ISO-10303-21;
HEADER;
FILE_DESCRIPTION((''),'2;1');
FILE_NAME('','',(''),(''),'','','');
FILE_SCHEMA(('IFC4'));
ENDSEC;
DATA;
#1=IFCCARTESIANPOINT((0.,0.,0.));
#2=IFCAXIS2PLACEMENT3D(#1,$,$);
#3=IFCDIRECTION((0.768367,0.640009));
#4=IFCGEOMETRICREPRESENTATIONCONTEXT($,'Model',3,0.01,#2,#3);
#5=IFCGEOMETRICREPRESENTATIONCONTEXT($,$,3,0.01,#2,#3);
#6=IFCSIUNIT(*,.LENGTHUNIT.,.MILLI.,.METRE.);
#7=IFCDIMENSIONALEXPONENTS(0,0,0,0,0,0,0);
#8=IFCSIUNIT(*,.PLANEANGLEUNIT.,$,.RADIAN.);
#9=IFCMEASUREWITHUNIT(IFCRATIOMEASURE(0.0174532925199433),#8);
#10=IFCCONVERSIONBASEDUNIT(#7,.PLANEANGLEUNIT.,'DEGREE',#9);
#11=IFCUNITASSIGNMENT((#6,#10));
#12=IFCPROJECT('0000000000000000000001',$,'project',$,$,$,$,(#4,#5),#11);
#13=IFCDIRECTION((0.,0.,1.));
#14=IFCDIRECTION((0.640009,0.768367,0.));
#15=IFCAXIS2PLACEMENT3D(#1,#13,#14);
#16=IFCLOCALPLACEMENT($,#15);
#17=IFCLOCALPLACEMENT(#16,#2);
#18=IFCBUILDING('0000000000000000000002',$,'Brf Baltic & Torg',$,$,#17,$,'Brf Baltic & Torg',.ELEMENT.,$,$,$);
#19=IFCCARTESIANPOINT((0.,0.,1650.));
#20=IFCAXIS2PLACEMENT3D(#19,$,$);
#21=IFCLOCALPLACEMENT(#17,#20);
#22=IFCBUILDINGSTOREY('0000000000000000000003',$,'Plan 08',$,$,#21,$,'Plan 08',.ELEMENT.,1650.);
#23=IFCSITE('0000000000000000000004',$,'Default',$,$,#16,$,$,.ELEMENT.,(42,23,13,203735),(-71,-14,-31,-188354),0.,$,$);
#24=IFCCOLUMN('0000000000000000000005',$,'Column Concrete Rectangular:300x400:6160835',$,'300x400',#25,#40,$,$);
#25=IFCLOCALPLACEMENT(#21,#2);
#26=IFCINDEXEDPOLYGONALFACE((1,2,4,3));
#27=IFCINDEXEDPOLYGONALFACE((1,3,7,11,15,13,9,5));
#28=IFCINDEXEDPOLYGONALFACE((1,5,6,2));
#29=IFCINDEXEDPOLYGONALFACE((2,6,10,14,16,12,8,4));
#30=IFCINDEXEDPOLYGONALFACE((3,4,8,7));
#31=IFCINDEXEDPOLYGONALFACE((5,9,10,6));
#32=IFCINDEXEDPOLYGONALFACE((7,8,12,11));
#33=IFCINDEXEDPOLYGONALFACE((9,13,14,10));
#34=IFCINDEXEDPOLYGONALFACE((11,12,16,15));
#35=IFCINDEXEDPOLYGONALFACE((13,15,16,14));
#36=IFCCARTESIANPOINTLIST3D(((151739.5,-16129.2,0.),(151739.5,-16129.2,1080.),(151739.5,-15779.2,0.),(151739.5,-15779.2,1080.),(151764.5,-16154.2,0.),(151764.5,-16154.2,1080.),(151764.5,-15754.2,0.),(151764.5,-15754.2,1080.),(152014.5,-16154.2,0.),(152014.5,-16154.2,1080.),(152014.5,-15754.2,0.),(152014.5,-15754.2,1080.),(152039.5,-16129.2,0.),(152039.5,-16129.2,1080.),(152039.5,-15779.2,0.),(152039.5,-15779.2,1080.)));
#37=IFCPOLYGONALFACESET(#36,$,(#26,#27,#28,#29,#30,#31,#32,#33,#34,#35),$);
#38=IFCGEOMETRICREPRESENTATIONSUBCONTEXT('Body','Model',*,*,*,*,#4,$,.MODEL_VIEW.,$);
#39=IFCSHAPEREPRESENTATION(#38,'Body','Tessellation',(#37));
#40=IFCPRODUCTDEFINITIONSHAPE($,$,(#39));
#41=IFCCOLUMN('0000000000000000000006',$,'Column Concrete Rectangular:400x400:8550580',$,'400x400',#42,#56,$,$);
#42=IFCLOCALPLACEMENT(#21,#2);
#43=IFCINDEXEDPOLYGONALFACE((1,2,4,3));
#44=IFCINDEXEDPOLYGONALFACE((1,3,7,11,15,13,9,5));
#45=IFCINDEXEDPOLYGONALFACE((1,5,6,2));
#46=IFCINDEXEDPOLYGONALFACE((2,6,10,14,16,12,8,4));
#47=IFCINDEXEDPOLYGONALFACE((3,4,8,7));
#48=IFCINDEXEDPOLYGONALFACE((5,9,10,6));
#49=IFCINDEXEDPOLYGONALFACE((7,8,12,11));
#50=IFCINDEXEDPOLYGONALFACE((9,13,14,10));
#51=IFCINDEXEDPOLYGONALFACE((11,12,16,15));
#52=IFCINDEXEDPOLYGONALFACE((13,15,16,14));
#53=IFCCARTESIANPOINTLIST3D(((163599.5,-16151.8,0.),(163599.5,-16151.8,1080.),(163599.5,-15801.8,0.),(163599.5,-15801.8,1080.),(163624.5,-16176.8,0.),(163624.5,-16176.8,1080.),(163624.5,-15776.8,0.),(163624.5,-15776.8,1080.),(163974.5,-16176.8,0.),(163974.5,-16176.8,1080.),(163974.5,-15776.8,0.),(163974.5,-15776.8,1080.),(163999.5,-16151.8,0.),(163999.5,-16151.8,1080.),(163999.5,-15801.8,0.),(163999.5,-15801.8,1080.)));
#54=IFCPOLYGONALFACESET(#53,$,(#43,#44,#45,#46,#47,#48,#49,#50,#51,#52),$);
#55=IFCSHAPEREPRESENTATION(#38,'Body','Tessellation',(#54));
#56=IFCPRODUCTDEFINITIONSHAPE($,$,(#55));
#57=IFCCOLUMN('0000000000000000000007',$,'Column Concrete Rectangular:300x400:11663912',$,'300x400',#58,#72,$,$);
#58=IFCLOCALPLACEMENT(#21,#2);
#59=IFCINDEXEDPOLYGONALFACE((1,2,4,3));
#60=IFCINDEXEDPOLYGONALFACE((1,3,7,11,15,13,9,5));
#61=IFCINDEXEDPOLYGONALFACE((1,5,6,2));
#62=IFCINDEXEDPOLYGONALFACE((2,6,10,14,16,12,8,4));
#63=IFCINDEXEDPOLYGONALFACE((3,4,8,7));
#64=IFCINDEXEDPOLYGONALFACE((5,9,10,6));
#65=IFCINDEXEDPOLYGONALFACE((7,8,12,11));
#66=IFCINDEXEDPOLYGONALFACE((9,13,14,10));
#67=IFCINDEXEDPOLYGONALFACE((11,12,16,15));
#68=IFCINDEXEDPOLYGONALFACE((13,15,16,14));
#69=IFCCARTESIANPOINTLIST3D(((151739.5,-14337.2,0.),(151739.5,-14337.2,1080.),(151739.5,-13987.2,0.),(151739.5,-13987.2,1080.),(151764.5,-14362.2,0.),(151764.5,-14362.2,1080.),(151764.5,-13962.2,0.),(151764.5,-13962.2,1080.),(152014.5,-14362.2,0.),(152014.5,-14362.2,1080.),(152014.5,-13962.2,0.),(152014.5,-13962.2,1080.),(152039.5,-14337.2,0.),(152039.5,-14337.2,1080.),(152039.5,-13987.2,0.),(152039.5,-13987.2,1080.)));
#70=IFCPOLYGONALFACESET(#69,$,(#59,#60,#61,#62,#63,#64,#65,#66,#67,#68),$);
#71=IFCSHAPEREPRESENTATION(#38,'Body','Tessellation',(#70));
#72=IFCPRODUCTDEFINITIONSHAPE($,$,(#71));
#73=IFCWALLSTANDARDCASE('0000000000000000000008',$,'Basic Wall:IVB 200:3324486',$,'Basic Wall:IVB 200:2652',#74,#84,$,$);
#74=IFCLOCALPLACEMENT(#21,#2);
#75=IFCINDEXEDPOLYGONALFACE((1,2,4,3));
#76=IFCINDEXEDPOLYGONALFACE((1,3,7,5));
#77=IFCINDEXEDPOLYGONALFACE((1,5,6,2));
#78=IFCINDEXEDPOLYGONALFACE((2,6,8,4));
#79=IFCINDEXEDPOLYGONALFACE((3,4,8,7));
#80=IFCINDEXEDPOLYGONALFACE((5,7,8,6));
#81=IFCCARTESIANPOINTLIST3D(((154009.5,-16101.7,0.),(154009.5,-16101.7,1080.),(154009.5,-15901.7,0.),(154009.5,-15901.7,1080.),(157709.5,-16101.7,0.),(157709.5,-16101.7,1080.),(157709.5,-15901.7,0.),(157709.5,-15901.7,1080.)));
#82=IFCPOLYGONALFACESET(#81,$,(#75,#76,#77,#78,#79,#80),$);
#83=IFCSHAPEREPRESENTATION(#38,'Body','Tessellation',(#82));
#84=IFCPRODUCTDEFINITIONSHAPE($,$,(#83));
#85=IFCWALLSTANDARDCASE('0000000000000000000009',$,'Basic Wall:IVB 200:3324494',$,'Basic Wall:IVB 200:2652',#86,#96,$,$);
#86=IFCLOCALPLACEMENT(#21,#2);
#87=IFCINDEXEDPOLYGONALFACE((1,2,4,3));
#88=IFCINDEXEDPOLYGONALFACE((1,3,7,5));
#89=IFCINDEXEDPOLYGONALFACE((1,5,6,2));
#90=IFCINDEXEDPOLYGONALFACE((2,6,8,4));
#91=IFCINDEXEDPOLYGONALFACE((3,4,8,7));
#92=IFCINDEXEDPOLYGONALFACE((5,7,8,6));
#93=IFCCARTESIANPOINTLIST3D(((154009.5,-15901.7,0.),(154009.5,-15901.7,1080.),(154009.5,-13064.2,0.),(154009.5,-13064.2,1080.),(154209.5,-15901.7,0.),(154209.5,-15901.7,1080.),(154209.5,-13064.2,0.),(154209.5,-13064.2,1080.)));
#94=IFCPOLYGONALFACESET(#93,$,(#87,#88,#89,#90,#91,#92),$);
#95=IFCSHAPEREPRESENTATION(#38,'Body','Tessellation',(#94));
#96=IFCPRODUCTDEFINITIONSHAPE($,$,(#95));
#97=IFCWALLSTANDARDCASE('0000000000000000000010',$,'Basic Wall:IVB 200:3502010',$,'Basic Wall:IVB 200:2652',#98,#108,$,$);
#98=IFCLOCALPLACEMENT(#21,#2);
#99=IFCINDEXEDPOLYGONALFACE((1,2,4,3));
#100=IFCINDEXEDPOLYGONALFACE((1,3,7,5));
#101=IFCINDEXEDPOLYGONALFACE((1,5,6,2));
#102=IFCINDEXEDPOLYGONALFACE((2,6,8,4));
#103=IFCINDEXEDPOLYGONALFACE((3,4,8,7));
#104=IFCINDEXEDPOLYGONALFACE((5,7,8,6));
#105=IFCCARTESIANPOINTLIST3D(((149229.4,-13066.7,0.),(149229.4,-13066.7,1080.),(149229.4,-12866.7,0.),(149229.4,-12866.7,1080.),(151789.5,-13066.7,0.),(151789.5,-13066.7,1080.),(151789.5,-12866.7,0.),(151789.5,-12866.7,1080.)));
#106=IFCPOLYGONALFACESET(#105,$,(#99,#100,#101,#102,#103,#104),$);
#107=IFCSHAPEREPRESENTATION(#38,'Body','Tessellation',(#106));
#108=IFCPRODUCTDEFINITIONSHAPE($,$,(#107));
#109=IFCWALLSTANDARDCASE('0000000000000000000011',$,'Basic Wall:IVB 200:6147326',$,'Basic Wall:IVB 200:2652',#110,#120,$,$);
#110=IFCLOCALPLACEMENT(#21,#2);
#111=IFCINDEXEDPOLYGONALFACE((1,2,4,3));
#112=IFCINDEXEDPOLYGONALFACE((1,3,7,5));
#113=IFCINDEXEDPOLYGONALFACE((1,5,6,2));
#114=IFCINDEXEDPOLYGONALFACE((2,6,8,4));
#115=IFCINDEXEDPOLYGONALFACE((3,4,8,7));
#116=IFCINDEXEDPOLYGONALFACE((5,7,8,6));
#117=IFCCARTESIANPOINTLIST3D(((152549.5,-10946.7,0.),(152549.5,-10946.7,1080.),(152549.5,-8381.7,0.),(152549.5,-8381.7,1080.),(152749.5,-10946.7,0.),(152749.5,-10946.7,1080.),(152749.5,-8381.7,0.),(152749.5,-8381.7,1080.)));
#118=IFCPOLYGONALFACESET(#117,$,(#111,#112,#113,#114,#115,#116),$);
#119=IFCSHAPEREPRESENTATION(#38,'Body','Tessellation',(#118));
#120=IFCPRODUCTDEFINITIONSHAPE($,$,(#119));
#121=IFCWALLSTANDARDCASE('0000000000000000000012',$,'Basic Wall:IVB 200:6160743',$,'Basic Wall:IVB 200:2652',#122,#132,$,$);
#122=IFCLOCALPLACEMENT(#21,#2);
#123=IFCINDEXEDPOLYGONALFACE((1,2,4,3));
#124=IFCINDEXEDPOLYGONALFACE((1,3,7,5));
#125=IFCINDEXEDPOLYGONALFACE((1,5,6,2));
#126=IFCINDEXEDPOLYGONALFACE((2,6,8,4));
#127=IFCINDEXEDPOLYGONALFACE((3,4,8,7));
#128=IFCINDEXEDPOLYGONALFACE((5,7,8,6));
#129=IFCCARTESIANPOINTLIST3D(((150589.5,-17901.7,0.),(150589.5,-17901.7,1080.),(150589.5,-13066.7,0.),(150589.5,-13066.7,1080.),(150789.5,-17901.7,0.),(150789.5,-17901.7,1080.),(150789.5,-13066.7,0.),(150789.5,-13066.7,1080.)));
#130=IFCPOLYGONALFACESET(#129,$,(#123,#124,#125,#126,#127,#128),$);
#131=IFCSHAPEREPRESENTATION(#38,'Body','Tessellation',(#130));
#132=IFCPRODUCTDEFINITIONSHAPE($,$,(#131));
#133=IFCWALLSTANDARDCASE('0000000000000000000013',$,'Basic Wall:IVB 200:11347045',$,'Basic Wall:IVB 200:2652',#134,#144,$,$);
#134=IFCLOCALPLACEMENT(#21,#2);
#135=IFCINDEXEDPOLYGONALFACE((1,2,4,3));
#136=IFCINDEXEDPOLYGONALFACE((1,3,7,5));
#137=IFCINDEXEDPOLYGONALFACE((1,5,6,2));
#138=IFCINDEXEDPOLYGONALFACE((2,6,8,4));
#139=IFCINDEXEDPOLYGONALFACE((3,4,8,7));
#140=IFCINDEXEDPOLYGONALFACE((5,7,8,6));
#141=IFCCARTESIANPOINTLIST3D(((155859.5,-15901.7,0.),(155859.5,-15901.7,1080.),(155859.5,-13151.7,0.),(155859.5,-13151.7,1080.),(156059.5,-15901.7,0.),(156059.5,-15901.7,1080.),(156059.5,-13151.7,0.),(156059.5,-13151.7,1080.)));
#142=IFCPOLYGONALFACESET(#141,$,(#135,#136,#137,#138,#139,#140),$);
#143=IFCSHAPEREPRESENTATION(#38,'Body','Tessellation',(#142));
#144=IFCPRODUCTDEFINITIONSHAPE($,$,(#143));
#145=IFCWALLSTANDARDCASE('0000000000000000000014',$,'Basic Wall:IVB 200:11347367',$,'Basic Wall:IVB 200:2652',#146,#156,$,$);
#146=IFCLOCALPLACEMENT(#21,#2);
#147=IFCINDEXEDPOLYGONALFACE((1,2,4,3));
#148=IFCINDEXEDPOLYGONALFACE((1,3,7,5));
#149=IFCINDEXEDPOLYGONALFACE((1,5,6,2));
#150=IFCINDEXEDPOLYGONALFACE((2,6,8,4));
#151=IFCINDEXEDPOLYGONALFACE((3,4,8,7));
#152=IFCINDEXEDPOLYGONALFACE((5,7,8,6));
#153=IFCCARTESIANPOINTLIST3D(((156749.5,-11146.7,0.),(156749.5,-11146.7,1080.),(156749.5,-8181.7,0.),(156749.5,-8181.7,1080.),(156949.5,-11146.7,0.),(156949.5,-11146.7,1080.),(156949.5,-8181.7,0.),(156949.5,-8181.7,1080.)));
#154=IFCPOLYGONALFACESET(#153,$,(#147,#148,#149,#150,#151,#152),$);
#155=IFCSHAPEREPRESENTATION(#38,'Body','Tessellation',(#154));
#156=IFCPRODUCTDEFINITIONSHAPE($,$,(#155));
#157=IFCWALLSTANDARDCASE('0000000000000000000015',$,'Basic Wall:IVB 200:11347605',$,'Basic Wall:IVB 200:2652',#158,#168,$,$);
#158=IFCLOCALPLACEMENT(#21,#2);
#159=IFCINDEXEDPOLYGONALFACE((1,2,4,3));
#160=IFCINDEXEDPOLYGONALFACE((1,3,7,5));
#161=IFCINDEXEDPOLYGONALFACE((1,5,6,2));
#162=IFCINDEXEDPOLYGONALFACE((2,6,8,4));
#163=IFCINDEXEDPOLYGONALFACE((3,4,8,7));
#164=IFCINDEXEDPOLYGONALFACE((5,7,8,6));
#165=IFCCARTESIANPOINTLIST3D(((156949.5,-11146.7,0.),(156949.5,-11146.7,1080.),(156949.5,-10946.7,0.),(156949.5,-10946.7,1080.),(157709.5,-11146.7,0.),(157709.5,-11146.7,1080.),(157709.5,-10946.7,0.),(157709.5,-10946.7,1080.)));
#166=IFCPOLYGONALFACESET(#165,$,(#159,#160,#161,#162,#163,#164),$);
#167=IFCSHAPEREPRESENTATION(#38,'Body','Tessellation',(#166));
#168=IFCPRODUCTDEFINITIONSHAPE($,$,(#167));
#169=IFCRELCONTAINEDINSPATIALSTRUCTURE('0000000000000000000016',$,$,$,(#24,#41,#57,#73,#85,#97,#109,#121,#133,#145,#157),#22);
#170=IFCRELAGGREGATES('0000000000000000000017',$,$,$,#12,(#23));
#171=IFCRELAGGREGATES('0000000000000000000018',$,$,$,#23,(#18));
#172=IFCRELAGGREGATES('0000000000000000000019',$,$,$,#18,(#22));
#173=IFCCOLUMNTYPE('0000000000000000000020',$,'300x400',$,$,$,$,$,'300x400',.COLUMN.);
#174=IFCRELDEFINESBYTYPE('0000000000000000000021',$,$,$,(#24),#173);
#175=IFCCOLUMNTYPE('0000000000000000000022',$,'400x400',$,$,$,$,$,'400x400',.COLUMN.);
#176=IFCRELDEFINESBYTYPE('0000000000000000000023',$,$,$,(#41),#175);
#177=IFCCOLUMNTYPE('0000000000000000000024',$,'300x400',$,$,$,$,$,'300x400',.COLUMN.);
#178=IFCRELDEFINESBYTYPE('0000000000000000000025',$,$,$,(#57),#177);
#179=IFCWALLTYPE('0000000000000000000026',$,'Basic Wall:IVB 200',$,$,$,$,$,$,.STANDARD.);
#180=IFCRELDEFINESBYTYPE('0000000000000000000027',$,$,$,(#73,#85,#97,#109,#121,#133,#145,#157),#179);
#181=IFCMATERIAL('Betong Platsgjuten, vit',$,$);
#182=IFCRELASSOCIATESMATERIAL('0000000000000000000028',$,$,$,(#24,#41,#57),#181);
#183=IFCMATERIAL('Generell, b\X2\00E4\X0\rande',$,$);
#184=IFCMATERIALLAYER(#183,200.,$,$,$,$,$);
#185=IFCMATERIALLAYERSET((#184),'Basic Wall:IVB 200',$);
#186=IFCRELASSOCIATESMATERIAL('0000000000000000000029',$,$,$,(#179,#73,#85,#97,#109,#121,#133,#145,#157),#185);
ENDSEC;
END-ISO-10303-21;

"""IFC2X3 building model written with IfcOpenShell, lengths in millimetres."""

from ifc_helpers import new_model, entity, si_unit, converted_unit, direction, frame, frame_2d, origin, place, context, subcontext, project, spatial, polyline, rectangle, outline, extrude, clip, halfspace, source, transform, mapped, material, layer, layer_set, layer_usage, type_object, type_shapes, element, save


model = new_model("IFC2X3")

# Units and contexts
model_context = context("Model", 3, precision=0.01, world=origin(), true_north=direction((0.768367, 0.640009)))
context_of_model = context(None, 3, precision=0.01, world=origin(), true_north=direction((0.768367, 0.640009)))
body_context = subcontext(model_context, "Body", "Model", "MODEL_VIEW")
ifc_project = project(units=[si_unit("LENGTHUNIT", "METRE", prefix="MILLI"), converted_unit("PLANEANGLEUNIT", "DEGREE", entity("IfcRatioMeasure", 0.0174532925199433), si_unit("PLANEANGLEUNIT", "RADIAN"), dimensions=[0, 0, 0, 0, 0, 0, 0])], contexts=[model_context, context_of_model])

# Site, building, storey
site_placement = place(None, frame((0.0, 0.0, 0.0), z_axis=(0.0, 0.0, 1.0), x_axis=(0.640009, 0.768367, 0.0)))
site = spatial("IfcSite", under=ifc_project, at=site_placement, Name="Default", CompositionType="ELEMENT", RefLatitude=(42, 23, 13, 203735), RefLongitude=(-71, -14, -31, -188354), RefElevation=0.0)
building_placement = place(site_placement, origin())
building = spatial("IfcBuilding", under=site, at=building_placement, Name="Brf Baltic & Torg", LongName="Brf Baltic & Torg", CompositionType="ELEMENT")
storey_placement = place(building_placement, frame((0.0, 0.0, 1650.0)))
storey = spatial("IfcBuildingStorey", under=building, at=storey_placement, Name="Plan 08", LongName="Plan 08", CompositionType="ELEMENT", Elevation=1650.0)

# Columns
ifc_material_1 = material(Name="Betong Platsgjuten, vit")
column_type_1 = type_object("IfcColumnType", Name="300x400", ElementType="300x400", PredefinedType="COLUMN")
shared_shape_1 = source(origin(), body_context, "Body", "SweptSolid", [
    extrude(outline(polyline([(-175.0, -150.0), (175.0, -150.0), (200.0, -125.0), (200.0, 125.0), (175.0, 150.0), (-175.0, 150.0), (-200.0, 125.0), (-200.0, -125.0), (-175.0, -150.0)])), frame((0.0, 0.0, 1650.0), z_axis=(0.0, 0.0, 1.0), x_axis=(0.0, -1.0, 0.0)), (0.0, 0.0, 1.0), 1080.0),
])
type_shapes(column_type_1, [shared_shape_1])
column_1_placement = place(storey_placement, frame((151889.5, -15954.2, -1650.0)))
element("IfcColumn", 1, at=column_1_placement, inside=storey, type_object=column_type_1, material=ifc_material_1, Name="Column Concrete Rectangular:300x400:6160835", ObjectType="300x400", context=body_context, shape_type="MappedRepresentation", body=[
    mapped(shared_shape_1, transform((0.0, 0.0, 0.0), scale=1.0)),
])
column_type_2 = type_object("IfcColumnType", Name="400x400", ElementType="400x400", PredefinedType="COLUMN")
shared_shape_2 = source(origin(), body_context, "Body", "SweptSolid", [
    extrude(outline(polyline([(-175.0, -200.0), (175.0, -200.0), (200.0, -175.0), (200.0, 175.0), (175.0, 200.0), (-175.0, 200.0), (-200.0, 175.0), (-200.0, -175.0), (-175.0, -200.0)])), frame((0.0, 0.0, 1650.0), z_axis=(0.0, 0.0, 1.0), x_axis=(0.0, -1.0, 0.0)), (0.0, 0.0, 1.0), 1080.0),
])
type_shapes(column_type_2, [shared_shape_2])
column_2_placement = place(storey_placement, frame((163799.5, -15976.8, -1650.0)))
element("IfcColumn", 2, at=column_2_placement, inside=storey, type_object=column_type_2, material=ifc_material_1, Name="Column Concrete Rectangular:400x400:8550580", ObjectType="400x400", context=body_context, shape_type="MappedRepresentation", body=[
    mapped(shared_shape_2, transform((0.0, 0.0, 0.0), scale=1.0)),
])
column_type_3 = type_object("IfcColumnType", Name="300x400", ElementType="300x400", PredefinedType="COLUMN")
shared_shape_3 = source(origin(), body_context, "Body", "SweptSolid", [
    extrude(outline(polyline([(-175.0, -150.0), (175.0, -150.0), (200.0, -125.0), (200.0, 125.0), (175.0, 150.0), (-175.0, 150.0), (-200.0, 125.0), (-200.0, -125.0), (-175.0, -150.0)])), frame((0.0, 0.0, 1650.0), z_axis=(0.0, 0.0, 1.0), x_axis=(0.0, -1.0, 0.0)), (0.0, 0.0, 1.0), 1080.0),
])
type_shapes(column_type_3, [shared_shape_3])
column_3_placement = place(storey_placement, frame((151889.5, -14162.2, -1650.0)))
element("IfcColumn", 3, at=column_3_placement, inside=storey, type_object=column_type_3, material=ifc_material_1, Name="Column Concrete Rectangular:300x400:11663912", ObjectType="300x400", context=body_context, shape_type="MappedRepresentation", body=[
    mapped(shared_shape_3, transform((0.0, 0.0, 0.0), scale=1.0)),
])

# Walls
ifc_material_2 = material(Name="Generell, bärande")
ifc_layer = layer(ifc_material_2, 200.0)
ifc_layer_set = layer_set([ifc_layer], Name="Basic Wall:IVB 200")
ifc_layer_usage_1 = layer_usage(ifc_layer_set, "AXIS2", "NEGATIVE", 100.0)
wall_type = type_object("IfcWallType", Name="Basic Wall:IVB 200", PredefinedType="STANDARD", material=ifc_layer_set)
wall_1_placement = place(storey_placement, frame((157709.5, -16001.7, 0.0), z_axis=(0.0, 0.0, 1.0), x_axis=(-1.0, 0.0, 0.0)))
element("IfcWallStandardCase", 4, at=wall_1_placement, inside=storey, type_object=wall_type, material=ifc_layer_usage_1, Name="Basic Wall:IVB 200:3324486", ObjectType="Basic Wall:IVB 200:2652", context=body_context, shape_type="Clipping", body=[
    clip(extrude(rectangle(XDim=3700.0, YDim=200.0, at=frame_2d((1850.0, 0.0), x_axis=(-1.0, 0.0))), origin(), (0.0, 0.0, 1.0), 1080.0), halfspace(origin(), True)),
])
ifc_layer_usage_2 = layer_usage(ifc_layer_set, "AXIS2", "NEGATIVE", 100.0)
wall_2_placement = place(storey_placement, frame((154109.5, -15901.7, 0.0), z_axis=(0.0, 0.0, 1.0), x_axis=(0.0, 1.0, 0.0)))
element("IfcWallStandardCase", 5, at=wall_2_placement, inside=storey, type_object=wall_type, material=ifc_layer_usage_2, Name="Basic Wall:IVB 200:3324494", ObjectType="Basic Wall:IVB 200:2652", context=body_context, shape_type="Clipping", body=[
    clip(extrude(rectangle(XDim=2837.5, YDim=200.0, at=frame_2d((1418.7, 0.0), x_axis=(-1.0, 0.0))), origin(), (0.0, 0.0, 1.0), 1080.0), halfspace(origin(), True)),
])

# Wall
ifc_layer_usage_3 = layer_usage(ifc_layer_set, "AXIS2", "NEGATIVE", 100.0)
wall_3_placement = place(storey_placement, frame((151789.5, -12966.7, 0.0), z_axis=(0.0, 0.0, 1.0), x_axis=(-1.0, 0.0, 0.0)))
element("IfcWallStandardCase", 6, at=wall_3_placement, inside=storey, type_object=wall_type, material=ifc_layer_usage_3, Name="Basic Wall:IVB 200:3502010", ObjectType="Basic Wall:IVB 200:2652", context=body_context, shape_type="Clipping", body=[
    clip(extrude(rectangle(XDim=2560.1, YDim=200.0, at=frame_2d((1280.0, 0.0), x_axis=(-1.0, 0.0))), origin(), (0.0, 0.0, 1.0), 1080.0), halfspace(origin(), True)),
])

# Walls
ifc_layer_usage_4 = layer_usage(ifc_layer_set, "AXIS2", "NEGATIVE", 100.0)
wall_4_placement = place(storey_placement, frame((152649.5, -10946.7, 0.0), z_axis=(0.0, 0.0, 1.0), x_axis=(0.0, 1.0, 0.0)))
element("IfcWallStandardCase", 7, at=wall_4_placement, inside=storey, type_object=wall_type, material=ifc_layer_usage_4, Name="Basic Wall:IVB 200:6147326", ObjectType="Basic Wall:IVB 200:2652", context=body_context, shape_type="Clipping", body=[
    clip(extrude(rectangle(XDim=2565.0, YDim=200.0, at=frame_2d((1282.5, 0.0), x_axis=(-1.0, 0.0))), origin(), (0.0, 0.0, 1.0), 1080.0), halfspace(origin(), True)),
])
ifc_layer_usage_5 = layer_usage(ifc_layer_set, "AXIS2", "POSITIVE", -100.0)
wall_5_placement = place(storey_placement, frame((150689.5, -13066.7, 0.0), z_axis=(0.0, 0.0, 1.0), x_axis=(0.0, -1.0, 0.0)))
element("IfcWallStandardCase", 8, at=wall_5_placement, inside=storey, type_object=wall_type, material=ifc_layer_usage_5, Name="Basic Wall:IVB 200:6160743", ObjectType="Basic Wall:IVB 200:2652", context=body_context, shape_type="Clipping", body=[
    clip(extrude(rectangle(XDim=4835.0, YDim=200.0, at=frame_2d((2417.5, 0.0), x_axis=(-1.0, 0.0))), origin(), (0.0, 0.0, 1.0), 1080.0), halfspace(origin(), True)),
])
ifc_layer_usage_6 = layer_usage(ifc_layer_set, "AXIS2", "NEGATIVE", 100.0)
wall_6_placement = place(storey_placement, frame((155959.5, -15901.7, 0.0), z_axis=(0.0, 0.0, 1.0), x_axis=(0.0, 1.0, 0.0)))
element("IfcWallStandardCase", 9, at=wall_6_placement, inside=storey, type_object=wall_type, material=ifc_layer_usage_6, Name="Basic Wall:IVB 200:11347045", ObjectType="Basic Wall:IVB 200:2652", context=body_context, shape_type="Clipping", body=[
    clip(extrude(rectangle(XDim=2750.0, YDim=200.0, at=frame_2d((1375.0, 0.0), x_axis=(-1.0, 0.0))), origin(), (0.0, 0.0, 1.0), 1080.0), halfspace(origin(), True)),
])
ifc_layer_usage_7 = layer_usage(ifc_layer_set, "AXIS2", "POSITIVE", -100.0)
wall_7_placement = place(storey_placement, frame((156849.5, -8181.7, 0.0), z_axis=(0.0, 0.0, 1.0), x_axis=(0.0, -1.0, 0.0)))
element("IfcWallStandardCase", 10, at=wall_7_placement, inside=storey, type_object=wall_type, material=ifc_layer_usage_7, Name="Basic Wall:IVB 200:11347367", ObjectType="Basic Wall:IVB 200:2652", context=body_context, shape_type="Clipping", body=[
    clip(extrude(rectangle(XDim=2965.0, YDim=200.0, at=frame_2d((1482.5, 0.0), x_axis=(-1.0, 0.0))), origin(), (0.0, 0.0, 1.0), 1080.0), halfspace(origin(), True)),
])
ifc_layer_usage_8 = layer_usage(ifc_layer_set, "AXIS2", "NEGATIVE", 100.0)
wall_8_placement = place(storey_placement, frame((156949.5, -11046.7, 0.0)))
element("IfcWallStandardCase", 11, at=wall_8_placement, inside=storey, type_object=wall_type, material=ifc_layer_usage_8, Name="Basic Wall:IVB 200:11347605", ObjectType="Basic Wall:IVB 200:2652", context=body_context, shape_type="Clipping", body=[
    clip(extrude(rectangle(XDim=760.0, YDim=200.0, at=frame_2d((380.0, 0.0), x_axis=(-1.0, 0.0))), origin(), (0.0, 0.0, 1.0), 1080.0), halfspace(origin(), True)),
])

save(model, "model.ifc")
